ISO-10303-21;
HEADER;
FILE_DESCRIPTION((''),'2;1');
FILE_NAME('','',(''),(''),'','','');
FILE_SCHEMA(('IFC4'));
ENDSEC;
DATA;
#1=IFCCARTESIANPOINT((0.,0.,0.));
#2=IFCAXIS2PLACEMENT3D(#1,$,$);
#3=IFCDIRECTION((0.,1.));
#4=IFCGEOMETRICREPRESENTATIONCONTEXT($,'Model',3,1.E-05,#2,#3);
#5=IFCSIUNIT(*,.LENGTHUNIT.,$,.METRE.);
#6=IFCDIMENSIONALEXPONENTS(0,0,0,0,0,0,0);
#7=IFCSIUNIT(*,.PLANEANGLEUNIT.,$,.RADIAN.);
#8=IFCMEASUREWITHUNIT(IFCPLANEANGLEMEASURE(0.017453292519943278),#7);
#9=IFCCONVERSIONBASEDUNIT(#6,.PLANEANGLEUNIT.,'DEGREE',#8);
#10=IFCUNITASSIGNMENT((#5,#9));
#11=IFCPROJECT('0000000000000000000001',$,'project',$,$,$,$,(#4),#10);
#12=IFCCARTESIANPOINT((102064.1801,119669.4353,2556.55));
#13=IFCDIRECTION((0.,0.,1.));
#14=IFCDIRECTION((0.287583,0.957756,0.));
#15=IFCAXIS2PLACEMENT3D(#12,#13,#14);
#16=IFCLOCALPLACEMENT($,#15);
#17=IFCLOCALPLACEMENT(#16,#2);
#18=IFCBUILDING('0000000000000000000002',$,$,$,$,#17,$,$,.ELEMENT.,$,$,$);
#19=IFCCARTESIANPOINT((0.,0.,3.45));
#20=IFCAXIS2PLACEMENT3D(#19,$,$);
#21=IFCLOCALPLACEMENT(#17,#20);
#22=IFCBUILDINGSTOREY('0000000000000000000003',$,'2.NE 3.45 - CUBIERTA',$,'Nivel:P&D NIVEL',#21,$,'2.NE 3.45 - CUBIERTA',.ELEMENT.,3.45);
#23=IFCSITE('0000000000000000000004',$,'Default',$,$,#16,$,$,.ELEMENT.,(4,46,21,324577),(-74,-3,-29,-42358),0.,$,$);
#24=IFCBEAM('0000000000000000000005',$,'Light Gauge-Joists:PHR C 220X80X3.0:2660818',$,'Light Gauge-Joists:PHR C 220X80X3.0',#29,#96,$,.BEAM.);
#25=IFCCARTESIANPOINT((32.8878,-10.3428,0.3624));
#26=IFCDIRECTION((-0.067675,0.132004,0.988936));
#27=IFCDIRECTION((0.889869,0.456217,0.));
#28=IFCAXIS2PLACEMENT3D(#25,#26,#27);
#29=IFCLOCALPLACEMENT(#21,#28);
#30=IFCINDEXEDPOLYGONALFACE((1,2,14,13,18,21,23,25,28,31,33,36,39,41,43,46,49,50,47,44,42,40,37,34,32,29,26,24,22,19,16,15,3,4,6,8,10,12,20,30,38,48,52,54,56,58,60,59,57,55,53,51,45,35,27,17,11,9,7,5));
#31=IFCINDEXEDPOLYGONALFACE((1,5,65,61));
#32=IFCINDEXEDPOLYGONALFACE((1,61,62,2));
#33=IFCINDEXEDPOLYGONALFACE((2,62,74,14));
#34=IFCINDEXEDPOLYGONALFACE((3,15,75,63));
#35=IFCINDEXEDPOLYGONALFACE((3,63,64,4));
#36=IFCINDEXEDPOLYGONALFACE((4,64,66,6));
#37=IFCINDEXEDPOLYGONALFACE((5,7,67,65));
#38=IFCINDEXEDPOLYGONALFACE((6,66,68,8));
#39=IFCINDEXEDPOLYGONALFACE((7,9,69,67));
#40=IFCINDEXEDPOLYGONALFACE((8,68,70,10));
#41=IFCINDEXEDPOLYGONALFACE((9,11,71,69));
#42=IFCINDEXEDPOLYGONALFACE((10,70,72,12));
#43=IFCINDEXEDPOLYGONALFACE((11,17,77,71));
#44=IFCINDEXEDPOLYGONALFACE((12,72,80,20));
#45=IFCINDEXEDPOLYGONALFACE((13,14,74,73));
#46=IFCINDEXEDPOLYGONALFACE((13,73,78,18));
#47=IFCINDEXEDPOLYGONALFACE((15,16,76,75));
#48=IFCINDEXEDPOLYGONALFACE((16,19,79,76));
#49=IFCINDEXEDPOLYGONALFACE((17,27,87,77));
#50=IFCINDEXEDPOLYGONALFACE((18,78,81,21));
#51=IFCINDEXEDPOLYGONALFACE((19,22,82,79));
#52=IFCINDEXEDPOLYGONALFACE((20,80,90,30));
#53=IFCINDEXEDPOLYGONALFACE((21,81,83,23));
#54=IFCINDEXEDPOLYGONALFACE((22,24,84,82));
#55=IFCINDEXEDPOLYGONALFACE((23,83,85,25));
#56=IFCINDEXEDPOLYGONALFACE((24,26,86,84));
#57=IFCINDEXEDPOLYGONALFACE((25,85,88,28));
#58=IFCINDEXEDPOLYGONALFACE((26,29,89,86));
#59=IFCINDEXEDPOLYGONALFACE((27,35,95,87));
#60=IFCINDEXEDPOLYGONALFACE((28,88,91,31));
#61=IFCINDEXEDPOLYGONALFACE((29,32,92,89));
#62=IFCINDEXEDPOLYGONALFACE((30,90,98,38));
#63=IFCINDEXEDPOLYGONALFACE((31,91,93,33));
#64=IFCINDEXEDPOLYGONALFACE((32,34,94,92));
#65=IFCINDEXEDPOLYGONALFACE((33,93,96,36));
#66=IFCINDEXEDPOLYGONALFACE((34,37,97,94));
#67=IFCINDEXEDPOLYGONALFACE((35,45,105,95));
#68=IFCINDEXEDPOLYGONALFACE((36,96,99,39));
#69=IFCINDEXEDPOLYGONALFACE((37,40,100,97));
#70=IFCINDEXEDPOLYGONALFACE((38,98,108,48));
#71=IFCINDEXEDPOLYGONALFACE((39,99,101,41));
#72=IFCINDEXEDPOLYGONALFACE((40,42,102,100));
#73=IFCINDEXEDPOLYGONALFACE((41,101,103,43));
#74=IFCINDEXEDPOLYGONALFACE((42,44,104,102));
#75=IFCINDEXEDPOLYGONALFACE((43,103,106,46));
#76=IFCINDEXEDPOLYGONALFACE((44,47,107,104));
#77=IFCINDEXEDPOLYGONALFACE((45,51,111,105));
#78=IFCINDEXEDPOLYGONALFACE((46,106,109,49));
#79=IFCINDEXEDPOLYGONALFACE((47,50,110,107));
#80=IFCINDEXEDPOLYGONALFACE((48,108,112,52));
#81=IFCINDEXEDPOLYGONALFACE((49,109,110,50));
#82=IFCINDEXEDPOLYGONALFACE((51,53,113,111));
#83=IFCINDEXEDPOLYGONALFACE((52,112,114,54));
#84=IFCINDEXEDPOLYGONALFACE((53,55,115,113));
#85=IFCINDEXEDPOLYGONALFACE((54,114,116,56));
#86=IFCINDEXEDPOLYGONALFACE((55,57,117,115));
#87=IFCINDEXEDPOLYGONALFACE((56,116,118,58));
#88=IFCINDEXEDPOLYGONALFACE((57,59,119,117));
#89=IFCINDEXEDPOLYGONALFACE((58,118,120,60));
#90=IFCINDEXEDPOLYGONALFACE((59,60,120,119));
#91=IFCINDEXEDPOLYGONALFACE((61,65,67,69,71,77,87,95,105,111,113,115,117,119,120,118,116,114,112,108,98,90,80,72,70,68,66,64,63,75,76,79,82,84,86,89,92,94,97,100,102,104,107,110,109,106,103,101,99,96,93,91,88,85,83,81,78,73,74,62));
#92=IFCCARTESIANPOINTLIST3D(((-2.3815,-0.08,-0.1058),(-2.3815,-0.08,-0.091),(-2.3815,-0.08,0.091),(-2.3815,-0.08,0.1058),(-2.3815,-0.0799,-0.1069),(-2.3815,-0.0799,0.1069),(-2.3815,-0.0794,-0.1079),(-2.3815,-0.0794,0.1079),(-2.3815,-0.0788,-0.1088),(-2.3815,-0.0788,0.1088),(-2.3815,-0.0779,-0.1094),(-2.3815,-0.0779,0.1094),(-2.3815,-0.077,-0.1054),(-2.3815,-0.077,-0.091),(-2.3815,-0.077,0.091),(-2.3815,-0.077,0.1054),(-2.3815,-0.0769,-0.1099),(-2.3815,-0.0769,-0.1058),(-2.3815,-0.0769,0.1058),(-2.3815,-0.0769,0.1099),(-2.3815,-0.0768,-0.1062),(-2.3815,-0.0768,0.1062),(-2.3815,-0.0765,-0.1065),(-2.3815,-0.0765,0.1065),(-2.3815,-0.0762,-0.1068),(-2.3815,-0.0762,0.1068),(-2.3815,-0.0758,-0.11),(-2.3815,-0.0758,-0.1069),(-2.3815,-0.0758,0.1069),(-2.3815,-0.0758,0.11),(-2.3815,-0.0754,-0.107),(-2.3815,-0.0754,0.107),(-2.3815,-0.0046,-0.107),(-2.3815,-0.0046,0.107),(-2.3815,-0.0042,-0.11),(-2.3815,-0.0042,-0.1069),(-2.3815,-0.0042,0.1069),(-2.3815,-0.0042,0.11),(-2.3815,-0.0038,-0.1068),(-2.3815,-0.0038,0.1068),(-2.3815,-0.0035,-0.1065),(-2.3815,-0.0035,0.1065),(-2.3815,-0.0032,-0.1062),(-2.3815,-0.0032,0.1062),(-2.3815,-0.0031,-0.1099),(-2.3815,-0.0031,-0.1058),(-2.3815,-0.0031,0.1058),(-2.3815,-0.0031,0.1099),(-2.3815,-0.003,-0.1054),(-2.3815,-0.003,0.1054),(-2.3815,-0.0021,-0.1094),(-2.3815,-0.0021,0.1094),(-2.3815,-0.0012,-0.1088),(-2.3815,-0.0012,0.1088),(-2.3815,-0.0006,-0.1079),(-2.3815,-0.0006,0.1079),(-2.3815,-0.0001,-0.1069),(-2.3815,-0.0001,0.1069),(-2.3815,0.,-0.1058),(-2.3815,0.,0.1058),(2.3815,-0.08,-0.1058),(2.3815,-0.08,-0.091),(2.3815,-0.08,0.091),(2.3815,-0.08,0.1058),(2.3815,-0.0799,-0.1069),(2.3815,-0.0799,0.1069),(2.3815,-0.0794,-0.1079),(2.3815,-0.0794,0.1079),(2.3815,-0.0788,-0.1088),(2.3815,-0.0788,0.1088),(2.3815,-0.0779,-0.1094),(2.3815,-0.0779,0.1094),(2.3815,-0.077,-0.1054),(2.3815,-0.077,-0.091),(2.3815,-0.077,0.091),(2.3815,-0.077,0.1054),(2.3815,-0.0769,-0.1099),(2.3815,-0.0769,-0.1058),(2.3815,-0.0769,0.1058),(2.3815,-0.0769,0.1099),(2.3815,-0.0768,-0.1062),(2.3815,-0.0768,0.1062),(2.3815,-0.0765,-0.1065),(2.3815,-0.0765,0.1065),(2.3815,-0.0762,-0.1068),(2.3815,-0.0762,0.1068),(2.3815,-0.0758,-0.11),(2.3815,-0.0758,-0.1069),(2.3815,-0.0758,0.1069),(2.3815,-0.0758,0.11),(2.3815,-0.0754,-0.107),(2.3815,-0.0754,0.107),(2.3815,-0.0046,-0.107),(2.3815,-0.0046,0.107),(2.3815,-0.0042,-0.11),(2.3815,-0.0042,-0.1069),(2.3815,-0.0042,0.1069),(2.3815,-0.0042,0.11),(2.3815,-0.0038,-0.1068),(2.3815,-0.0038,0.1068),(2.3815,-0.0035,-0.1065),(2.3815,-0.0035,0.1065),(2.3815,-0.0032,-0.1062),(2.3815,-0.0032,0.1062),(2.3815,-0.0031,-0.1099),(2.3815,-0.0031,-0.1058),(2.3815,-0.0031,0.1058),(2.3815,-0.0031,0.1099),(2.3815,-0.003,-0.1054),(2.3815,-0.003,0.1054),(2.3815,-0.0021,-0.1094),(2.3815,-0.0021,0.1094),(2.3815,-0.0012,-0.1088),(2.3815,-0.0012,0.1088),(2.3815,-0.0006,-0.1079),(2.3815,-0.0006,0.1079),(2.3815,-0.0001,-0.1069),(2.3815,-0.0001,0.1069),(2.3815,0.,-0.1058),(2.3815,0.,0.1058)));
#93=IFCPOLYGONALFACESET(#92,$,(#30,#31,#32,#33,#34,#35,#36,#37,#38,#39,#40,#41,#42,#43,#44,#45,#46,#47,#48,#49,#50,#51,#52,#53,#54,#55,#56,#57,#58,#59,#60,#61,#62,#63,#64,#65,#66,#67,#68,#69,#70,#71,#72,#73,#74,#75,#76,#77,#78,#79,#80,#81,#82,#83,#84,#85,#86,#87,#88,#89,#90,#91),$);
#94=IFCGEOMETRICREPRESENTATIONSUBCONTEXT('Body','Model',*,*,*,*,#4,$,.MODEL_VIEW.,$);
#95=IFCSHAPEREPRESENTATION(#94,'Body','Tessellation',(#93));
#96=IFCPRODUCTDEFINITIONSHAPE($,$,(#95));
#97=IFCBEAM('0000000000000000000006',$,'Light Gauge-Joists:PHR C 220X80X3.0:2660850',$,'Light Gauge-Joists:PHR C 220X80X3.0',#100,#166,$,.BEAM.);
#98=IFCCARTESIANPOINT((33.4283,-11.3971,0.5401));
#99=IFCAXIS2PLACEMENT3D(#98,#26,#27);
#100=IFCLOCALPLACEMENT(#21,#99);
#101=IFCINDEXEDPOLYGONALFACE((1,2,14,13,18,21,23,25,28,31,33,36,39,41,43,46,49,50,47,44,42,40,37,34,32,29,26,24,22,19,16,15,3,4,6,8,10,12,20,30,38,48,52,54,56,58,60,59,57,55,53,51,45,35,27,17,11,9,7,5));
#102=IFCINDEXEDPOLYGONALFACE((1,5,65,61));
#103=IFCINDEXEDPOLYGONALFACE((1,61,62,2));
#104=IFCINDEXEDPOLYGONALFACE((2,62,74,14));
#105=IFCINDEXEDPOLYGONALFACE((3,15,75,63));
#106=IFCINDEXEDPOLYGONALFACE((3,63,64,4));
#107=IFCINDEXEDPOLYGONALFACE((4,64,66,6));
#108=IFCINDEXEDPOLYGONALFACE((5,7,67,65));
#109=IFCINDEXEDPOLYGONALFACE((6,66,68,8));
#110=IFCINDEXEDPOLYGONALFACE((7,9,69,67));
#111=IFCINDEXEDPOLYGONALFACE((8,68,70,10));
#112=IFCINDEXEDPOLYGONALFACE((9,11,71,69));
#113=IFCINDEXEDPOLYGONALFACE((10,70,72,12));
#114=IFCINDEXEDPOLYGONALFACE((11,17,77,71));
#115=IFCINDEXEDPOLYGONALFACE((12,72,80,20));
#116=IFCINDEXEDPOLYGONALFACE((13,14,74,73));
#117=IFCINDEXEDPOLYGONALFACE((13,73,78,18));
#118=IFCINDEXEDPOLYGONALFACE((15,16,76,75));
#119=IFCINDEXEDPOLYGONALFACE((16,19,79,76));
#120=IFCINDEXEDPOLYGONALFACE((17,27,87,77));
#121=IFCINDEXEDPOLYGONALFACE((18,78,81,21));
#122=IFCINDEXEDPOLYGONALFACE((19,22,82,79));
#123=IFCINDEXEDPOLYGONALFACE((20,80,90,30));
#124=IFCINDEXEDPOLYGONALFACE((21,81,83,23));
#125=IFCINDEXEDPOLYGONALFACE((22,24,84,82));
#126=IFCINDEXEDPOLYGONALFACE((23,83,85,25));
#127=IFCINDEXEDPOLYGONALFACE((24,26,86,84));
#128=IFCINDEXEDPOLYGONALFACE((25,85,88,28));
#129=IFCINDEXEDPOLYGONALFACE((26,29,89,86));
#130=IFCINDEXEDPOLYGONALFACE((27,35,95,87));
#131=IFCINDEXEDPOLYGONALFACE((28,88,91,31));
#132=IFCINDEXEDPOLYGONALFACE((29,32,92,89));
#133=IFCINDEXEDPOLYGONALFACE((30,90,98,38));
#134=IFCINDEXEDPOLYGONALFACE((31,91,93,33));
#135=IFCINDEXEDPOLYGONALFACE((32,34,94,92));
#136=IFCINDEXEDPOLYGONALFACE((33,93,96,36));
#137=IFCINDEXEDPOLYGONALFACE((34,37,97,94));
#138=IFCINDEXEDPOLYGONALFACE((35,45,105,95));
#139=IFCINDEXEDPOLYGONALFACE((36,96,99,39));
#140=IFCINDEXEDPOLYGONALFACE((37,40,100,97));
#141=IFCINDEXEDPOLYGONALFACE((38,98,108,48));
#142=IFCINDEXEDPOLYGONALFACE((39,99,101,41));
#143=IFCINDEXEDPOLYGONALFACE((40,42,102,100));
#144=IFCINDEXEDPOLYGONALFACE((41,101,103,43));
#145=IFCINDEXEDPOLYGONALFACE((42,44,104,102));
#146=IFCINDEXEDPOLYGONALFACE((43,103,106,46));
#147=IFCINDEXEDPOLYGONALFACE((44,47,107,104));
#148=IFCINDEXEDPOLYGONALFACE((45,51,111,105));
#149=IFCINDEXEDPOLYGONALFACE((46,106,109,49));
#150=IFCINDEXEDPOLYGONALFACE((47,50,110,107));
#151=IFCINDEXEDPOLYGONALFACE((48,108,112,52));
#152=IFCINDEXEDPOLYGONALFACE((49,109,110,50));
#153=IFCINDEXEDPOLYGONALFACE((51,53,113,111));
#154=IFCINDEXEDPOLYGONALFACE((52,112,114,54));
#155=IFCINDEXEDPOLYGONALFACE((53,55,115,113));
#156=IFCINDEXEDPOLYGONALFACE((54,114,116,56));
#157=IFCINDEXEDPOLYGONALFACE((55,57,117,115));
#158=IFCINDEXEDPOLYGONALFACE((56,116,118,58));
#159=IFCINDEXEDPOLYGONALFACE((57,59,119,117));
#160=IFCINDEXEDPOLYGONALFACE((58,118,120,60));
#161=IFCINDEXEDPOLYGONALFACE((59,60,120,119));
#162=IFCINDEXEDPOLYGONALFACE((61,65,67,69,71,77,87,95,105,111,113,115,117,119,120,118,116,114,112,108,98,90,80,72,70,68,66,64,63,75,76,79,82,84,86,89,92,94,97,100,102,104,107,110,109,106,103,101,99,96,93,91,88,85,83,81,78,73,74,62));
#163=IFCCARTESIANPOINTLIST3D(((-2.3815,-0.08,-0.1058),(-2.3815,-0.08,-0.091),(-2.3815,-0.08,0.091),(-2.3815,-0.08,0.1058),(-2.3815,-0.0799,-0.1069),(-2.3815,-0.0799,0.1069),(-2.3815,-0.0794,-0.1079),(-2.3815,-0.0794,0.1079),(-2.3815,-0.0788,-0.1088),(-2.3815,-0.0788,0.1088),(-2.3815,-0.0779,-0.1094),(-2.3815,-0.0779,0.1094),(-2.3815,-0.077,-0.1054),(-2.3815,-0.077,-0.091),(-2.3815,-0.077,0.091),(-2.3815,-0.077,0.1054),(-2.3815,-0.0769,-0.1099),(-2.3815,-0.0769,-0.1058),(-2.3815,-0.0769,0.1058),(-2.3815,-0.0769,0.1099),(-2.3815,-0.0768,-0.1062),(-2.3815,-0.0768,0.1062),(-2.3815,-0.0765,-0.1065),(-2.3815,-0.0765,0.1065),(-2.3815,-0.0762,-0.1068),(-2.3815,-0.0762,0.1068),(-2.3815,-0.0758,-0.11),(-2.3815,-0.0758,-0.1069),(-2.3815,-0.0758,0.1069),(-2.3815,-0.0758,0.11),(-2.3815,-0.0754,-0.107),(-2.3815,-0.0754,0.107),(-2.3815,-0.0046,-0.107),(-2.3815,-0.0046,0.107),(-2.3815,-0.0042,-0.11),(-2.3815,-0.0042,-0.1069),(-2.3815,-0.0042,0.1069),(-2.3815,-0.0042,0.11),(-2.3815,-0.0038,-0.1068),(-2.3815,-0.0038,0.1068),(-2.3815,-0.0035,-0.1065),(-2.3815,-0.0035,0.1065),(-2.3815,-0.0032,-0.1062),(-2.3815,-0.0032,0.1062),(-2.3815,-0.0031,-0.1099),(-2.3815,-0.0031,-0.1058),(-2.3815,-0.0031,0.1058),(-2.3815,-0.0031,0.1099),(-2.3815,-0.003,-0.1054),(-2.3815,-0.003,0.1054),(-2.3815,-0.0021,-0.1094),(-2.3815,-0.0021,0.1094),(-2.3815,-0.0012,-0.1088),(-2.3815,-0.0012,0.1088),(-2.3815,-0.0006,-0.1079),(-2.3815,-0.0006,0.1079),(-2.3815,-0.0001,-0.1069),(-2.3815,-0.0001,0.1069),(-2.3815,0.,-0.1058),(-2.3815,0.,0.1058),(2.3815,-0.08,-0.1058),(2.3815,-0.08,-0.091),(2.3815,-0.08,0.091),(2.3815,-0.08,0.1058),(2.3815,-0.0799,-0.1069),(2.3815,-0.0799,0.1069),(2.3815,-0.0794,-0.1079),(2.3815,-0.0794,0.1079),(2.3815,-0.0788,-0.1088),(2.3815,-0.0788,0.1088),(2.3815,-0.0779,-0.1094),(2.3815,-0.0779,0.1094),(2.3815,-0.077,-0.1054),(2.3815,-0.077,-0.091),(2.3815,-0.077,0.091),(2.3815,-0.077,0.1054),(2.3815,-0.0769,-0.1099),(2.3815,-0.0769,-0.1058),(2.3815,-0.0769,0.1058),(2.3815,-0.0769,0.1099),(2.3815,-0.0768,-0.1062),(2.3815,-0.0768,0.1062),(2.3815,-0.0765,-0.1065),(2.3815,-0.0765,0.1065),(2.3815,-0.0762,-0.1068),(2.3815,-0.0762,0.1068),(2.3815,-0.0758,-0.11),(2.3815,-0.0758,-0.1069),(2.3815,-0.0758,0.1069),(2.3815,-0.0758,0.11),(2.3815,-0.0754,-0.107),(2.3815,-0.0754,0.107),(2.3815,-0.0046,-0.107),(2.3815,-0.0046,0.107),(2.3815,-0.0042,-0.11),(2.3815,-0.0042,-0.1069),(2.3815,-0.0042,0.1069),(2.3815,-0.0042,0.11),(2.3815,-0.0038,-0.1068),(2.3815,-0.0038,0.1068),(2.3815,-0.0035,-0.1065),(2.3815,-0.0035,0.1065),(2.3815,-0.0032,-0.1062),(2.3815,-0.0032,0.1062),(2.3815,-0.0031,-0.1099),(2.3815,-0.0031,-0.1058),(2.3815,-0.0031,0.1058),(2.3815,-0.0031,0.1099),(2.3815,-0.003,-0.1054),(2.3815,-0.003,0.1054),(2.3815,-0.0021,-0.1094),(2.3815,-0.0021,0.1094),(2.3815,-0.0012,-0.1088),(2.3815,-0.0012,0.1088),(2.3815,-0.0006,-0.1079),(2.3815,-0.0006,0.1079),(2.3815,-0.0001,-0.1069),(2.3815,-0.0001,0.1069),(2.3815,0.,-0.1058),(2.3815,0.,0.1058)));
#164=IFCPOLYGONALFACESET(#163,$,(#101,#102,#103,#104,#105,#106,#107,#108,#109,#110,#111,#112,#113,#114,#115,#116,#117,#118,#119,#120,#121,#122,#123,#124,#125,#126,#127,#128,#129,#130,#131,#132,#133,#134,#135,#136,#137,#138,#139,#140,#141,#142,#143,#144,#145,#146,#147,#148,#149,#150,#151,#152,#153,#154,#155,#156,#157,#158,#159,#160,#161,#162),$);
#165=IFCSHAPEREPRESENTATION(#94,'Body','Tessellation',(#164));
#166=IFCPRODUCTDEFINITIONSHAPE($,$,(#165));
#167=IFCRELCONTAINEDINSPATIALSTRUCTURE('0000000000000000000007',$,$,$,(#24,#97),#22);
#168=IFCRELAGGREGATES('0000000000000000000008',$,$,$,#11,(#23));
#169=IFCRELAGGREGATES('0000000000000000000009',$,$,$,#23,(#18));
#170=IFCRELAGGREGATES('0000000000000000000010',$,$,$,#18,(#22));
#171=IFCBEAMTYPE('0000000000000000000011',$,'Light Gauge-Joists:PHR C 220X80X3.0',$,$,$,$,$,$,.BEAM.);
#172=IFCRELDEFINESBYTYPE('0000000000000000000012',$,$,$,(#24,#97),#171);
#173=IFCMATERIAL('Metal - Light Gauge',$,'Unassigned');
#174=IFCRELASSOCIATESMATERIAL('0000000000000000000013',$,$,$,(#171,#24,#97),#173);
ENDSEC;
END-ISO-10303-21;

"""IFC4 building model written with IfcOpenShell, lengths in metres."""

from ifc_helpers import new_model, entity, si_unit, converted_unit, direction, frame, origin, place, context, subcontext, project, spatial, line, arc, indexed_curve, outline, extrude, source, transform, mapped, material, type_object, type_shapes, element, save


model = new_model("IFC4")

# Units and contexts
model_context = context("Model", 3, precision=1e-05, world=origin(), true_north=direction((0.0, 1.0)))
body_context = subcontext(model_context, "Body", "Model", "MODEL_VIEW")
ifc_project = project(units=[si_unit("LENGTHUNIT", "METRE"), converted_unit("PLANEANGLEUNIT", "DEGREE", entity("IfcPlaneAngleMeasure", 0.017453292519943278), si_unit("PLANEANGLEUNIT", "RADIAN"), dimensions=[0, 0, 0, 0, 0, 0, 0])], contexts=[model_context])

# Site, building, storey
site_placement = place(None, frame((102064.1801, 119669.4353, 2556.55), z_axis=(0.0, 0.0, 1.0), x_axis=(0.287583, 0.957756, 0.0)))
site = spatial("IfcSite", under=ifc_project, at=site_placement, Name="Default", CompositionType="ELEMENT", RefLatitude=(4, 46, 21, 324577), RefLongitude=(-74, -3, -29, -42358), RefElevation=0.0)
building_placement = place(site_placement, origin())
building = spatial("IfcBuilding", under=site, at=building_placement, CompositionType="ELEMENT")
storey_placement = place(building_placement, frame((0.0, 0.0, 3.45)))
storey = spatial("IfcBuildingStorey", under=building, at=storey_placement, Name="2.NE 3.45 - CUBIERTA", ObjectType="Nivel:P&D NIVEL", LongName="2.NE 3.45 - CUBIERTA", CompositionType="ELEMENT", Elevation=3.45)

# Beams
ifc_material_1 = material(Name="Metal - Light Gauge", Category="Unassigned")
beam_type_1 = type_object("IfcBeamType", Name="Light Gauge-Joists:PHR C 220X80X3.0", PredefinedType="BEAM", material=ifc_material_1)
shared_shape_1 = source(origin(), body_context, "Body", "SweptSolid", [
    extrude(outline(indexed_curve([(-0.1058, -0.0477), (0.1058, -0.0477), (0.1088, -0.0465), (0.11, -0.0435), (0.11, 0.0281), (0.1088, 0.0311), (0.1058, 0.0323), (0.091, 0.0323), (0.091, 0.0293), (0.1054, 0.0293), (0.1065, 0.0288), (0.107, 0.0277), (0.107, -0.0431), (0.1065, -0.0442), (0.1054, -0.0447), (-0.1054, -0.0447), (-0.1065, -0.0442), (-0.107, -0.0431), (-0.107, 0.0277), (-0.1065, 0.0288), (-0.1054, 0.0293), (-0.091, 0.0293), (-0.091, 0.0323), (-0.1058, 0.0323), (-0.1088, 0.0311), (-0.11, 0.0281), (-0.11, -0.0435), (-0.1088, -0.0465)], segments=[line(1, 2), arc(2, 3, 4), line(4, 5), arc(5, 6, 7), line(7, 8, 9, 10), arc(10, 11, 12), line(12, 13), arc(13, 14, 15), line(15, 16), arc(16, 17, 18), line(18, 19), arc(19, 20, 21), line(21, 22, 23, 24), arc(24, 25, 26), line(26, 27), arc(27, 28, 1)], self_intersect=False)), frame((-2.3815, -0.0477, 0.0), z_axis=(1.0, 0.0, 0.0), x_axis=(0.0, 0.0, 1.0)), (0.0, 0.0, 1.0), 4.763),
])
type_shapes(beam_type_1, [shared_shape_1])
for number, where, z_axis, x_axis, name in (
    (1, (32.8878, -10.3428, 0.3624), (-0.067675, 0.132004, 0.988936), (0.889869, 0.456217, 0.0), "Light Gauge-Joists:PHR C 220X80X3.0:2660818"),
    (2, (33.4283, -11.3971, 0.5401), (-0.067675, 0.132004, 0.988936), (0.889869, 0.456217, 0.0), "Light Gauge-Joists:PHR C 220X80X3.0:2660850"),
):
    element("IfcBeam", number, at=place(storey_placement, frame(where, z_axis=z_axis, x_axis=x_axis)), inside=storey, type_object=beam_type_1, material=ifc_material_1, Name=name, ObjectType="Light Gauge-Joists:PHR C 220X80X3.0", PredefinedType="BEAM", context=body_context, shape_type="MappedRepresentation", body=[
        mapped(shared_shape_1, transform((0.0, 0.0, 0.0), scale=1.0)),
    ])

save(model, "model.ifc")
